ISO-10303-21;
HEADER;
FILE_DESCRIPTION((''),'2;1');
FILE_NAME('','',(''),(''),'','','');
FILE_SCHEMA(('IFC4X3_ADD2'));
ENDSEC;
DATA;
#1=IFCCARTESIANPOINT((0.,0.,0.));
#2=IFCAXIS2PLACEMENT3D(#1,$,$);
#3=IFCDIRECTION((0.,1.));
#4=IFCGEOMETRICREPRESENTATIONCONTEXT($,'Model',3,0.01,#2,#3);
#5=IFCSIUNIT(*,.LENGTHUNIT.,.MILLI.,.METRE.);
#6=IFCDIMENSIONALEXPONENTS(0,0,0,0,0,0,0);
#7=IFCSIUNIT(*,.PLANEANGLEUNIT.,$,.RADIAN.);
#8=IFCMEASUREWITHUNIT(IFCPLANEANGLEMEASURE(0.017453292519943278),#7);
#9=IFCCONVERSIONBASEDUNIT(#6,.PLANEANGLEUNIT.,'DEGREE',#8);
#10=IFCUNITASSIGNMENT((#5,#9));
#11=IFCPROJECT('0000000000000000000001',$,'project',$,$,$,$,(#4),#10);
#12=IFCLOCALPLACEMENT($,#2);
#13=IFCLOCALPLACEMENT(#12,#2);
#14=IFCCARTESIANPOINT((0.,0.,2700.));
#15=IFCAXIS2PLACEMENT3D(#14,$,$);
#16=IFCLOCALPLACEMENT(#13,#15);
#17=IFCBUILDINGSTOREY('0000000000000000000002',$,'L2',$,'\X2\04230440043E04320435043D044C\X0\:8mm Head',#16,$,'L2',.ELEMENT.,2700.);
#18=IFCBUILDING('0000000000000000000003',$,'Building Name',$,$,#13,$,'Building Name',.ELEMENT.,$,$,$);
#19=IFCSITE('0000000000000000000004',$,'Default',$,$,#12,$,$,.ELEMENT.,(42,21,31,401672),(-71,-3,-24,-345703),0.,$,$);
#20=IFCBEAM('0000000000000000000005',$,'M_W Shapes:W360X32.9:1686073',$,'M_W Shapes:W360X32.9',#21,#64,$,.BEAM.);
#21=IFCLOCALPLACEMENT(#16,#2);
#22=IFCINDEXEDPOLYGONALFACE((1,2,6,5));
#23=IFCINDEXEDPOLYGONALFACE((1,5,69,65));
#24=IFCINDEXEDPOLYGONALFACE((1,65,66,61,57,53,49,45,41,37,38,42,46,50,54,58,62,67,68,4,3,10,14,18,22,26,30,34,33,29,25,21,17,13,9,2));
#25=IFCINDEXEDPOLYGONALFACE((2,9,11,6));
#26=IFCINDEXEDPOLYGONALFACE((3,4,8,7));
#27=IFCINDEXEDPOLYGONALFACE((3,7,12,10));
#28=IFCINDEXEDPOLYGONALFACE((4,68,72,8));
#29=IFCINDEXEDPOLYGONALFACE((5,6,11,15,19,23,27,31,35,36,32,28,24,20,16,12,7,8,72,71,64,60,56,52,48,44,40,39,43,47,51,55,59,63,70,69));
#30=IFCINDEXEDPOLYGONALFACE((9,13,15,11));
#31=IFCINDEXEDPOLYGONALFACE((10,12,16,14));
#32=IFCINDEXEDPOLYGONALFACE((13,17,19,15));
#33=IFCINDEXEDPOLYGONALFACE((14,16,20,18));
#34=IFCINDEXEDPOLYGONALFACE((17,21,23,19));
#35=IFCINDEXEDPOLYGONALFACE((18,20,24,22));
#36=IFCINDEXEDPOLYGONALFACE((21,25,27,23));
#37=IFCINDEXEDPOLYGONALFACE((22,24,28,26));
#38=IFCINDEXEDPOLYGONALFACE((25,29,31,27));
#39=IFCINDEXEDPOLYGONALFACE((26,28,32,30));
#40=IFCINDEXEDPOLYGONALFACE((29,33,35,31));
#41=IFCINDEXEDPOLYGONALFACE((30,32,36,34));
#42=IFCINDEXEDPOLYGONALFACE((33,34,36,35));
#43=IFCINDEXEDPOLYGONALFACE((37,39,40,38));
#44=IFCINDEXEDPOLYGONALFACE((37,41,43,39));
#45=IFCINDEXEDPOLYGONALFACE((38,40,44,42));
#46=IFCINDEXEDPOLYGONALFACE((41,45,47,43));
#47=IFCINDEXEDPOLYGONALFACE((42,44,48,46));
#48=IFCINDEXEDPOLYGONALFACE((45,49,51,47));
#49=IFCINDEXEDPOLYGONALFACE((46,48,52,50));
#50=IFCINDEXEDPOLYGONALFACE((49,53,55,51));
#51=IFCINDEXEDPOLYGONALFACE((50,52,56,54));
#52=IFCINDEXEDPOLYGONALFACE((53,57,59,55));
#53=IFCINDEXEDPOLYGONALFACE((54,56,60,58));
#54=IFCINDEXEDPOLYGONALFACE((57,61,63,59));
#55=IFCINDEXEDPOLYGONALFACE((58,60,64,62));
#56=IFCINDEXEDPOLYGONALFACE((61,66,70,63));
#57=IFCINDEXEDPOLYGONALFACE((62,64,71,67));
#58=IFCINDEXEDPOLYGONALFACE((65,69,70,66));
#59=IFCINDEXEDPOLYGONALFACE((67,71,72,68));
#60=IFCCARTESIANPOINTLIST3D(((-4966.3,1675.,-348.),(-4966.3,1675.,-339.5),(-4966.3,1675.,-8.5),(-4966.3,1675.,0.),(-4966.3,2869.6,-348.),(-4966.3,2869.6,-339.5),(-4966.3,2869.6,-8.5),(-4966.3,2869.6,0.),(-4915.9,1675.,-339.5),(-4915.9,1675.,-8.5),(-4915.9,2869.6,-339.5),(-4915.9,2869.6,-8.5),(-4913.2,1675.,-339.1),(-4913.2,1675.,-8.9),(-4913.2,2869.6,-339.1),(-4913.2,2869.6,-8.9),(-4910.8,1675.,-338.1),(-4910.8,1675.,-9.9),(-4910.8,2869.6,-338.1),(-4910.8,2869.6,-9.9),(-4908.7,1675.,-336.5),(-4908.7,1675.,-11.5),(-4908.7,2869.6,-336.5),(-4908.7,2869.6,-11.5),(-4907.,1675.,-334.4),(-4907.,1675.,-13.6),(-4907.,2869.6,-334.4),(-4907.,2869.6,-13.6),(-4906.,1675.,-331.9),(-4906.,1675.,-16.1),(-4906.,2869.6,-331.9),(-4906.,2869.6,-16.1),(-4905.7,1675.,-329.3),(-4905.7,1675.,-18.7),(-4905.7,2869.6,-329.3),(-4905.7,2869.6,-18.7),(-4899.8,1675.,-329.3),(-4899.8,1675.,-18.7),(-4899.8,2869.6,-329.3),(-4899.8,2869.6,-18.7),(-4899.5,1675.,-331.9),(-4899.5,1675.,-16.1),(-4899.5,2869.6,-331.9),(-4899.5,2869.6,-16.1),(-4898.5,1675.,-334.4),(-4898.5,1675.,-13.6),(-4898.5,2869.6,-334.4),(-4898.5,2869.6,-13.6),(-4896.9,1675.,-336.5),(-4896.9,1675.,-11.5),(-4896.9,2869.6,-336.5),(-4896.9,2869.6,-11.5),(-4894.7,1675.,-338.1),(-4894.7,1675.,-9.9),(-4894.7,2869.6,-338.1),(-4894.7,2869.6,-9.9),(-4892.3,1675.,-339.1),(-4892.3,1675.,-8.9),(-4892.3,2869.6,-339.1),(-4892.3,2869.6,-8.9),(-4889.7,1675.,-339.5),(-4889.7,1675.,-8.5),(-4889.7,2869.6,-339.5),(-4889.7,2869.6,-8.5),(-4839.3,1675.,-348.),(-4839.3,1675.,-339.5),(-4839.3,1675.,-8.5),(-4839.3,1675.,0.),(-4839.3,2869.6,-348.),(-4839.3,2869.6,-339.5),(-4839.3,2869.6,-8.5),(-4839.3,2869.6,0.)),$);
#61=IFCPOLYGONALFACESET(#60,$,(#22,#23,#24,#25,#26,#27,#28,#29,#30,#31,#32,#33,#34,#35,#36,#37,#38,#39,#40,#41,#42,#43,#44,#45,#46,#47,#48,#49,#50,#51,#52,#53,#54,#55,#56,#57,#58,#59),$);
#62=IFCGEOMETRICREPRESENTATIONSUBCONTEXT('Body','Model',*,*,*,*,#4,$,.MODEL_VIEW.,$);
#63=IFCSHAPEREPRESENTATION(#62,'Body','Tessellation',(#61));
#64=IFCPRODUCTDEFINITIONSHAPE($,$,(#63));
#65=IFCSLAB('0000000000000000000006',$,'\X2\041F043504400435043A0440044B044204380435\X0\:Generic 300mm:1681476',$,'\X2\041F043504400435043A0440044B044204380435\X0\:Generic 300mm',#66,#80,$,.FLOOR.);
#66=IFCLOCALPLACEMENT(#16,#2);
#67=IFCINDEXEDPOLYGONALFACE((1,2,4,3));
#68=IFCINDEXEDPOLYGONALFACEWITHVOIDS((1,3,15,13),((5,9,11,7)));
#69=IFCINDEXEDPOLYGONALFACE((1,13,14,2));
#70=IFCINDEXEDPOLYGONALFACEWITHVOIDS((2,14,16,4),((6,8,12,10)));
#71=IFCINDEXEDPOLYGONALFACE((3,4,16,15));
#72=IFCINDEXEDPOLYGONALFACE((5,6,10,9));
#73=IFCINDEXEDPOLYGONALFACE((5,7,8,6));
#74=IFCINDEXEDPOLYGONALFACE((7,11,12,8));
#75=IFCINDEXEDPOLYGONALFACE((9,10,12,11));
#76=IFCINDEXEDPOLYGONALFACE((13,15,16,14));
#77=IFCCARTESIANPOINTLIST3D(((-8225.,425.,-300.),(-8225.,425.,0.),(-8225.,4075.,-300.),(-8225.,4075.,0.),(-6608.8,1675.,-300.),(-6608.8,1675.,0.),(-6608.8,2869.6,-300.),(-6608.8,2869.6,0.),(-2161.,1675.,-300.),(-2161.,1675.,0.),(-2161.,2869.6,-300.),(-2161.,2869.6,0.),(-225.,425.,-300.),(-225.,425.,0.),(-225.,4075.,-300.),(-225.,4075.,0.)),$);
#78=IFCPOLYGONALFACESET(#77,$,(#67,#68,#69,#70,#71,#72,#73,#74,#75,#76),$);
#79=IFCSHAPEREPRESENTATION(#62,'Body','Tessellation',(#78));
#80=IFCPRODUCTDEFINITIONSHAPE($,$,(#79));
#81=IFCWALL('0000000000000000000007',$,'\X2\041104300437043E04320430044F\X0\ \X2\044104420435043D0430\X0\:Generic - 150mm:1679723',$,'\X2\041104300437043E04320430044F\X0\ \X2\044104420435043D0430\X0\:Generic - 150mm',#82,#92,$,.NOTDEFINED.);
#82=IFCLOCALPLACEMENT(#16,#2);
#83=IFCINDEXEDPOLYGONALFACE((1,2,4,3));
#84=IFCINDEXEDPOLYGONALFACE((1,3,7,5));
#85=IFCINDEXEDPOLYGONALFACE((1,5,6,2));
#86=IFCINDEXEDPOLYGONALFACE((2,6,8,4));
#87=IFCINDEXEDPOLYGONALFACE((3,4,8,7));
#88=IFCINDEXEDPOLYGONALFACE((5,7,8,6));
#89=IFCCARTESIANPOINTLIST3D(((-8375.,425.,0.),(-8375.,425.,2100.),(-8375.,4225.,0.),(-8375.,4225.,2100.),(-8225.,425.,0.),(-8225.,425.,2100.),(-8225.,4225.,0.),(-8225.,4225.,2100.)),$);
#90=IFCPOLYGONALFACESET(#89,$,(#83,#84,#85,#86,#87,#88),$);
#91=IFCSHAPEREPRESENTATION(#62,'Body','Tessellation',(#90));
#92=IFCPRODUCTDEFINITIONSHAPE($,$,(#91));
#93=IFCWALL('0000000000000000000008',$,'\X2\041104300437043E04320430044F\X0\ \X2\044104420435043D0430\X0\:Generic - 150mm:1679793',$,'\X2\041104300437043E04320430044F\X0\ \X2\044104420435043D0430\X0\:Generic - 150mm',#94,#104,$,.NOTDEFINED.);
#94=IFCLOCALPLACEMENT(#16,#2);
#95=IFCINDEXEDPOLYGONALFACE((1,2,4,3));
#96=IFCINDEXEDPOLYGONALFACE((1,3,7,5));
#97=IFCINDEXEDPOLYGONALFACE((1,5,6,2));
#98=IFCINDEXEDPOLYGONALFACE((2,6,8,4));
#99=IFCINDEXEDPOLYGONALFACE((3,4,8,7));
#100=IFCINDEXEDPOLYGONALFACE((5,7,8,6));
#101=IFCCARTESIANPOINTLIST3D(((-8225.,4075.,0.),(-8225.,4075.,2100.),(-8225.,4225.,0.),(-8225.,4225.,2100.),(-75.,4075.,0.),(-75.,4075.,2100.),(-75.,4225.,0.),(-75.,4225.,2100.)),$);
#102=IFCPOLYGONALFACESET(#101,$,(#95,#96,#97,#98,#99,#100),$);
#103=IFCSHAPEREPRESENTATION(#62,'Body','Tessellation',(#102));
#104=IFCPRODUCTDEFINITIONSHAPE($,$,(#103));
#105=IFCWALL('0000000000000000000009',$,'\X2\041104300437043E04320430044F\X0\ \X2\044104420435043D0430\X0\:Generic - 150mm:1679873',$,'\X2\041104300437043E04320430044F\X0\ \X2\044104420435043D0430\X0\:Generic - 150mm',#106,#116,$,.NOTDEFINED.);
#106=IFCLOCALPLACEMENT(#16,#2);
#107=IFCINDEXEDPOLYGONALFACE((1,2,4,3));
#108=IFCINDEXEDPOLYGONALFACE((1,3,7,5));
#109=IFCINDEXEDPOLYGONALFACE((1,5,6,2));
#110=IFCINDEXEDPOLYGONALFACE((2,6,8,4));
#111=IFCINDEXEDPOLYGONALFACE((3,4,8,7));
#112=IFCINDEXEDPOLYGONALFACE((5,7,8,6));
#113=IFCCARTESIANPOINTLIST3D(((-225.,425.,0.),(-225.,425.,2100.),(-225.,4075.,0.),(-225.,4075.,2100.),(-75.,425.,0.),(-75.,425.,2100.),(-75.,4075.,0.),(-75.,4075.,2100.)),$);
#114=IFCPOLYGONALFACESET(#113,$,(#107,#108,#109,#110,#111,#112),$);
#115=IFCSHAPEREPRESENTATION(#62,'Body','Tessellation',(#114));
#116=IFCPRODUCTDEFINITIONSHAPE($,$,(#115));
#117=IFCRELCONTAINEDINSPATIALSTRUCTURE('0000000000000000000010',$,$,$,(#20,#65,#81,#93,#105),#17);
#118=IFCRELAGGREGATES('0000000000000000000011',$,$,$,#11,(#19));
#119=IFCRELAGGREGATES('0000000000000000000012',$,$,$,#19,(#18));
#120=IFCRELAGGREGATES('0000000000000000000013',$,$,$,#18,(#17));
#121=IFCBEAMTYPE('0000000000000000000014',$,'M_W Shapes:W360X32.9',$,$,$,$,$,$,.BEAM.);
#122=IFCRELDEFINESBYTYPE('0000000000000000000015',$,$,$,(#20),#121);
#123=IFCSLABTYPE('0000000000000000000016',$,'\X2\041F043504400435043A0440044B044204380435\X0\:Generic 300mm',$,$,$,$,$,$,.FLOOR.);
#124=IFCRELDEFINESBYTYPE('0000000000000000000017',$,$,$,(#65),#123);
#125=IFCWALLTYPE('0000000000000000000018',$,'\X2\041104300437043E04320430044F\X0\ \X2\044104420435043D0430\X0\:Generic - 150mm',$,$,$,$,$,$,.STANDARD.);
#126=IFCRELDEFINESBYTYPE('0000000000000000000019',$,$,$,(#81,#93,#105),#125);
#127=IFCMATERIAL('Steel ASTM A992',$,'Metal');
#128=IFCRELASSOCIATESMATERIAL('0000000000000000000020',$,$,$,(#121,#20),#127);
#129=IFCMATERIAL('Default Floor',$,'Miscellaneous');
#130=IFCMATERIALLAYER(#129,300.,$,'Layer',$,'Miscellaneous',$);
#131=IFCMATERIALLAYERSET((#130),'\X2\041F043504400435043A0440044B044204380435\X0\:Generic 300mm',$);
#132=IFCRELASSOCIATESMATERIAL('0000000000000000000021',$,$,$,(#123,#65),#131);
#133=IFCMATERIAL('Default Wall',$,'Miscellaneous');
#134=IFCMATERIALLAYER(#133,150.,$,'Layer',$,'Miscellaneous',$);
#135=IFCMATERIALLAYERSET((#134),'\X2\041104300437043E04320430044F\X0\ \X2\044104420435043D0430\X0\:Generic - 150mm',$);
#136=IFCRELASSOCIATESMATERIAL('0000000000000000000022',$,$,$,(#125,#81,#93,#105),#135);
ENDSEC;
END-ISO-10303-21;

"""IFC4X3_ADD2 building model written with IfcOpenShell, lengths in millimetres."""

from ifc_helpers import new_model, entity, si_unit, converted_unit, direction, frame, frame_2d, origin, place, context, subcontext, project, spatial, polyline, circle_curve, parameter, trimmed, segment, composite_curve, rectangle, outline, extrude, boolean, source, transform, mapped, material, layer, layer_set, layer_usage, material_profile, profile_set, profile_usage, type_object, type_shapes, element, save


model = new_model("IFC4X3_ADD2")

# Units and contexts
model_context = context("Model", 3, precision=0.01, world=origin(), true_north=direction((0.0, 1.0)))
body_context = subcontext(model_context, "Body", "Model", "MODEL_VIEW")
ifc_project = project(units=[si_unit("LENGTHUNIT", "METRE", prefix="MILLI"), converted_unit("PLANEANGLEUNIT", "DEGREE", entity("IfcPlaneAngleMeasure", 0.017453292519943278), si_unit("PLANEANGLEUNIT", "RADIAN"), dimensions=[0, 0, 0, 0, 0, 0, 0])], contexts=[model_context])

# Site, building, storey
site_placement = place(None, origin())
site = spatial("IfcSite", under=ifc_project, at=site_placement, Name="Default", CompositionType="ELEMENT", RefLatitude=(42, 21, 31, 401672), RefLongitude=(-71, -3, -24, -345703), RefElevation=0.0)
building_placement = place(site_placement, origin())
building = spatial("IfcBuilding", under=site, at=building_placement, Name="Building Name", LongName="Building Name", CompositionType="ELEMENT")
storey_placement = place(building_placement, frame((0.0, 0.0, 2700.0)))
storey = spatial("IfcBuildingStorey", under=building, at=storey_placement, Name="L2", ObjectType="Уровень:8mm Head", LongName="L2", CompositionType="ELEMENT", Elevation=2700.0)

# Beam
ifc_material_1 = material(Name="Steel ASTM A992", Category="Metal")
ifc_material_profile = material_profile(ifc_material_1, outline(composite_curve([segment(polyline([(-63.5, -165.5), (-63.5, -174.0)]), True, "CONTINUOUS"), segment(polyline([(-63.5, -174.0), (63.5, -174.0)]), True, "CONTINUOUS"), segment(polyline([(63.5, -174.0), (63.5, -165.5)]), True, "CONTINUOUS"), segment(polyline([(63.5, -165.5), (13.1, -165.5)]), True, "CONTINUOUS"), segment(trimmed(circle_curve(frame_2d((13.1, -155.3), x_axis=(1.0, 0.0)), 10.2), [parameter(180.0)], [parameter(270.0)], True, "PARAMETER"), False, "CONTINUOUS"), segment(polyline([(2.9, -155.3), (2.9, 155.3)]), True, "CONTINUOUS"), segment(trimmed(circle_curve(frame_2d((13.1, 155.3), x_axis=(1.0, 0.0)), 10.2), [parameter(90.0)], [parameter(180.0)], True, "PARAMETER"), False, "CONTINUOUS"), segment(polyline([(13.1, 165.5), (63.5, 165.5)]), True, "CONTINUOUS"), segment(polyline([(63.5, 165.5), (63.5, 174.0)]), True, "CONTINUOUS"), segment(polyline([(63.5, 174.0), (-63.5, 174.0)]), True, "CONTINUOUS"), segment(polyline([(-63.5, 174.0), (-63.5, 165.5)]), True, "CONTINUOUS"), segment(polyline([(-63.5, 165.5), (-13.1, 165.5)]), True, "CONTINUOUS"), segment(trimmed(circle_curve(frame_2d((-13.1, 155.3), x_axis=(1.0, 0.0)), 10.2), [parameter(360.0)], [parameter(90.0)], True, "PARAMETER"), False, "CONTINUOUS"), segment(polyline([(-2.9, 155.3), (-2.9, -155.3)]), True, "CONTINUOUS"), segment(trimmed(circle_curve(frame_2d((-13.1, -155.3), x_axis=(1.0, 0.0)), 10.2), [parameter(270.0)], [parameter(0.0)], True, "PARAMETER"), False, "CONTINUOUS"), segment(polyline([(-13.1, -165.5), (-63.5, -165.5)]), True, "CONTINUOUS")], self_intersect=False)), Name="W360X32.9")
ifc_profile_set = profile_set([ifc_material_profile], Name="W360X32.9")
ifc_profile_usage = profile_usage(ifc_profile_set, cardinal=8)
beam_type = type_object("IfcBeamType", Name="M_W Shapes:W360X32.9", PredefinedType="BEAM", material=ifc_profile_set)
shared_shape = source(origin(), body_context, "Body", "SweptSolid", [
    extrude(outline(composite_curve([segment(polyline([(-63.5, -165.5), (-63.5, -174.0)]), True, "CONTINUOUS"), segment(polyline([(-63.5, -174.0), (63.5, -174.0)]), True, "CONTINUOUS"), segment(polyline([(63.5, -174.0), (63.5, -165.5)]), True, "CONTINUOUS"), segment(polyline([(63.5, -165.5), (13.1, -165.5)]), True, "CONTINUOUS"), segment(trimmed(circle_curve(frame_2d((13.1, -155.3), x_axis=(1.0, 0.0)), 10.2), [parameter(180.0)], [parameter(270.0)], True, "PARAMETER"), False, "CONTINUOUS"), segment(polyline([(2.9, -155.3), (2.9, 155.3)]), True, "CONTINUOUS"), segment(trimmed(circle_curve(frame_2d((13.1, 155.3), x_axis=(1.0, 0.0)), 10.2), [parameter(90.0)], [parameter(180.0)], True, "PARAMETER"), False, "CONTINUOUS"), segment(polyline([(13.1, 165.5), (63.5, 165.5)]), True, "CONTINUOUS"), segment(polyline([(63.5, 165.5), (63.5, 174.0)]), True, "CONTINUOUS"), segment(polyline([(63.5, 174.0), (-63.5, 174.0)]), True, "CONTINUOUS"), segment(polyline([(-63.5, 174.0), (-63.5, 165.5)]), True, "CONTINUOUS"), segment(polyline([(-63.5, 165.5), (-13.1, 165.5)]), True, "CONTINUOUS"), segment(trimmed(circle_curve(frame_2d((-13.1, 155.3), x_axis=(1.0, 0.0)), 10.2), [parameter(360.0)], [parameter(90.0)], True, "PARAMETER"), False, "CONTINUOUS"), segment(polyline([(-2.9, 155.3), (-2.9, -155.3)]), True, "CONTINUOUS"), segment(trimmed(circle_curve(frame_2d((-13.1, -155.3), x_axis=(1.0, 0.0)), 10.2), [parameter(270.0)], [parameter(0.0)], True, "PARAMETER"), False, "CONTINUOUS"), segment(polyline([(-13.1, -165.5), (-63.5, -165.5)]), True, "CONTINUOUS")], self_intersect=False)), frame((-597.3, 0.0, 0.0), z_axis=(-1.0, 0.0, 0.0), x_axis=(0.0, -1.0, 0.0)), (0.0, 0.0, -1.0), 1194.6),
])
type_shapes(beam_type, [shared_shape])
beam_placement = place(storey_placement, frame((-4902.8, 2272.3, -174.0), z_axis=(0.0, 0.0, 1.0), x_axis=(0.0, -1.0, 0.0)))
element("IfcBeam", 1, at=beam_placement, inside=storey, type_object=beam_type, material=ifc_profile_usage, Name="M_W Shapes:W360X32.9:1686073", ObjectType="M_W Shapes:W360X32.9", PredefinedType="BEAM", context=body_context, shape_type="MappedRepresentation", body=[
    mapped(shared_shape, transform((0.0, 0.0, 0.0), scale=1.0)),
])

# Slab, opening
ifc_material_2 = material(Name="Default Floor", Category="Miscellaneous")
ifc_layer_1 = layer(ifc_material_2, 300.0, Name="Layer", Category="Miscellaneous")
ifc_layer_set_1 = layer_set([ifc_layer_1], Name="Перекрытие:Generic 300mm")
ifc_layer_usage = layer_usage(ifc_layer_set_1, "AXIS3", "POSITIVE", 0.0)
slab_type = type_object("IfcSlabType", Name="Перекрытие:Generic 300mm", PredefinedType="FLOOR", material=ifc_layer_set_1)
slab_placement = place(storey_placement, origin())
slab = element("IfcSlab", 2, at=slab_placement, inside=storey, type_object=slab_type, material=ifc_layer_usage, Name="Перекрытие:Generic 300mm:1681476", ObjectType="Перекрытие:Generic 300mm", PredefinedType="FLOOR", context=body_context, shape_type="CSG", body=[
    boolean("DIFFERENCE", extrude(rectangle(XDim=3650.0, YDim=8000.0, at=frame_2d((0.0, 0.0), x_axis=(1.0, 0.0))), frame((-4225.0, 2250.0, 0.0), z_axis=(0.0, 0.0, -1.0), x_axis=(0.0, 1.0, 0.0)), (0.0, 0.0, 1.0), 300.0), extrude(rectangle(XDim=1194.6, YDim=4447.8, at=frame_2d((0.0, 0.0), x_axis=(1.0, 0.0))), frame((-4384.9, 2272.3, -300.0), z_axis=(0.0, 0.0, 1.0), x_axis=(0.0, 1.0, 0.0)), (0.0, 0.0, 1.0), 300.0)),
])
opening_placement = place(slab_placement, origin())
element("IfcOpeningElement", 3, at=opening_placement, cuts=slab, PredefinedType="OPENING", context=body_context, shape_type="SweptSolid", body=[
    extrude(rectangle(XDim=1194.6, YDim=4447.8, at=frame_2d((-4384.9, 2272.3), x_axis=(0.0, -1.0))), origin(), (0.0, 0.0, -1.0), 300.0),
])

# Walls
ifc_material_3 = material(Name="Default Wall", Category="Miscellaneous")
ifc_layer_2 = layer(ifc_material_3, 150.0, Name="Layer", Category="Miscellaneous")
ifc_layer_set_2 = layer_set([ifc_layer_2], Name="Базовая стена:Generic - 150mm")
wall_type = type_object("IfcWallType", Name="Базовая стена:Generic - 150mm", PredefinedType="STANDARD", material=ifc_layer_set_2)
wall_1_placement = place(storey_placement, frame((-8300.0, 425.0, 0.0), z_axis=(0.0, 0.0, 1.0), x_axis=(0.0, 1.0, 0.0)))
element("IfcWall", 4, at=wall_1_placement, inside=storey, type_object=wall_type, material=ifc_layer_set_2, Name="Базовая стена:Generic - 150mm:1679723", ObjectType="Базовая стена:Generic - 150mm", PredefinedType="NOTDEFINED", context=body_context, shape_type="SweptSolid", body=[
    extrude(rectangle(XDim=3800.0, YDim=150.0, at=frame_2d((1900.0, 0.0), x_axis=(-1.0, 0.0))), origin(), (0.0, 0.0, 1.0), 2100.0),
])
wall_2_placement = place(storey_placement, frame((-8225.0, 4150.0, 0.0)))
element("IfcWall", 5, at=wall_2_placement, inside=storey, type_object=wall_type, material=ifc_layer_set_2, Name="Базовая стена:Generic - 150mm:1679793", ObjectType="Базовая стена:Generic - 150mm", PredefinedType="NOTDEFINED", context=body_context, shape_type="SweptSolid", body=[
    extrude(rectangle(XDim=8150.0, YDim=150.0, at=frame_2d((4075.0, 0.0), x_axis=(-1.0, 0.0))), origin(), (0.0, 0.0, 1.0), 2100.0),
])
wall_3_placement = place(storey_placement, frame((-150.0, 4075.0, 0.0), z_axis=(0.0, 0.0, 1.0), x_axis=(0.0, -1.0, 0.0)))
element("IfcWall", 6, at=wall_3_placement, inside=storey, type_object=wall_type, material=ifc_layer_set_2, Name="Базовая стена:Generic - 150mm:1679873", ObjectType="Базовая стена:Generic - 150mm", PredefinedType="NOTDEFINED", context=body_context, shape_type="SweptSolid", body=[
    extrude(rectangle(XDim=3650.0, YDim=150.0, at=frame_2d((1825.0, 0.0), x_axis=(-1.0, 0.0))), origin(), (0.0, 0.0, 1.0), 2100.0),
])

save(model, "model.ifc")
